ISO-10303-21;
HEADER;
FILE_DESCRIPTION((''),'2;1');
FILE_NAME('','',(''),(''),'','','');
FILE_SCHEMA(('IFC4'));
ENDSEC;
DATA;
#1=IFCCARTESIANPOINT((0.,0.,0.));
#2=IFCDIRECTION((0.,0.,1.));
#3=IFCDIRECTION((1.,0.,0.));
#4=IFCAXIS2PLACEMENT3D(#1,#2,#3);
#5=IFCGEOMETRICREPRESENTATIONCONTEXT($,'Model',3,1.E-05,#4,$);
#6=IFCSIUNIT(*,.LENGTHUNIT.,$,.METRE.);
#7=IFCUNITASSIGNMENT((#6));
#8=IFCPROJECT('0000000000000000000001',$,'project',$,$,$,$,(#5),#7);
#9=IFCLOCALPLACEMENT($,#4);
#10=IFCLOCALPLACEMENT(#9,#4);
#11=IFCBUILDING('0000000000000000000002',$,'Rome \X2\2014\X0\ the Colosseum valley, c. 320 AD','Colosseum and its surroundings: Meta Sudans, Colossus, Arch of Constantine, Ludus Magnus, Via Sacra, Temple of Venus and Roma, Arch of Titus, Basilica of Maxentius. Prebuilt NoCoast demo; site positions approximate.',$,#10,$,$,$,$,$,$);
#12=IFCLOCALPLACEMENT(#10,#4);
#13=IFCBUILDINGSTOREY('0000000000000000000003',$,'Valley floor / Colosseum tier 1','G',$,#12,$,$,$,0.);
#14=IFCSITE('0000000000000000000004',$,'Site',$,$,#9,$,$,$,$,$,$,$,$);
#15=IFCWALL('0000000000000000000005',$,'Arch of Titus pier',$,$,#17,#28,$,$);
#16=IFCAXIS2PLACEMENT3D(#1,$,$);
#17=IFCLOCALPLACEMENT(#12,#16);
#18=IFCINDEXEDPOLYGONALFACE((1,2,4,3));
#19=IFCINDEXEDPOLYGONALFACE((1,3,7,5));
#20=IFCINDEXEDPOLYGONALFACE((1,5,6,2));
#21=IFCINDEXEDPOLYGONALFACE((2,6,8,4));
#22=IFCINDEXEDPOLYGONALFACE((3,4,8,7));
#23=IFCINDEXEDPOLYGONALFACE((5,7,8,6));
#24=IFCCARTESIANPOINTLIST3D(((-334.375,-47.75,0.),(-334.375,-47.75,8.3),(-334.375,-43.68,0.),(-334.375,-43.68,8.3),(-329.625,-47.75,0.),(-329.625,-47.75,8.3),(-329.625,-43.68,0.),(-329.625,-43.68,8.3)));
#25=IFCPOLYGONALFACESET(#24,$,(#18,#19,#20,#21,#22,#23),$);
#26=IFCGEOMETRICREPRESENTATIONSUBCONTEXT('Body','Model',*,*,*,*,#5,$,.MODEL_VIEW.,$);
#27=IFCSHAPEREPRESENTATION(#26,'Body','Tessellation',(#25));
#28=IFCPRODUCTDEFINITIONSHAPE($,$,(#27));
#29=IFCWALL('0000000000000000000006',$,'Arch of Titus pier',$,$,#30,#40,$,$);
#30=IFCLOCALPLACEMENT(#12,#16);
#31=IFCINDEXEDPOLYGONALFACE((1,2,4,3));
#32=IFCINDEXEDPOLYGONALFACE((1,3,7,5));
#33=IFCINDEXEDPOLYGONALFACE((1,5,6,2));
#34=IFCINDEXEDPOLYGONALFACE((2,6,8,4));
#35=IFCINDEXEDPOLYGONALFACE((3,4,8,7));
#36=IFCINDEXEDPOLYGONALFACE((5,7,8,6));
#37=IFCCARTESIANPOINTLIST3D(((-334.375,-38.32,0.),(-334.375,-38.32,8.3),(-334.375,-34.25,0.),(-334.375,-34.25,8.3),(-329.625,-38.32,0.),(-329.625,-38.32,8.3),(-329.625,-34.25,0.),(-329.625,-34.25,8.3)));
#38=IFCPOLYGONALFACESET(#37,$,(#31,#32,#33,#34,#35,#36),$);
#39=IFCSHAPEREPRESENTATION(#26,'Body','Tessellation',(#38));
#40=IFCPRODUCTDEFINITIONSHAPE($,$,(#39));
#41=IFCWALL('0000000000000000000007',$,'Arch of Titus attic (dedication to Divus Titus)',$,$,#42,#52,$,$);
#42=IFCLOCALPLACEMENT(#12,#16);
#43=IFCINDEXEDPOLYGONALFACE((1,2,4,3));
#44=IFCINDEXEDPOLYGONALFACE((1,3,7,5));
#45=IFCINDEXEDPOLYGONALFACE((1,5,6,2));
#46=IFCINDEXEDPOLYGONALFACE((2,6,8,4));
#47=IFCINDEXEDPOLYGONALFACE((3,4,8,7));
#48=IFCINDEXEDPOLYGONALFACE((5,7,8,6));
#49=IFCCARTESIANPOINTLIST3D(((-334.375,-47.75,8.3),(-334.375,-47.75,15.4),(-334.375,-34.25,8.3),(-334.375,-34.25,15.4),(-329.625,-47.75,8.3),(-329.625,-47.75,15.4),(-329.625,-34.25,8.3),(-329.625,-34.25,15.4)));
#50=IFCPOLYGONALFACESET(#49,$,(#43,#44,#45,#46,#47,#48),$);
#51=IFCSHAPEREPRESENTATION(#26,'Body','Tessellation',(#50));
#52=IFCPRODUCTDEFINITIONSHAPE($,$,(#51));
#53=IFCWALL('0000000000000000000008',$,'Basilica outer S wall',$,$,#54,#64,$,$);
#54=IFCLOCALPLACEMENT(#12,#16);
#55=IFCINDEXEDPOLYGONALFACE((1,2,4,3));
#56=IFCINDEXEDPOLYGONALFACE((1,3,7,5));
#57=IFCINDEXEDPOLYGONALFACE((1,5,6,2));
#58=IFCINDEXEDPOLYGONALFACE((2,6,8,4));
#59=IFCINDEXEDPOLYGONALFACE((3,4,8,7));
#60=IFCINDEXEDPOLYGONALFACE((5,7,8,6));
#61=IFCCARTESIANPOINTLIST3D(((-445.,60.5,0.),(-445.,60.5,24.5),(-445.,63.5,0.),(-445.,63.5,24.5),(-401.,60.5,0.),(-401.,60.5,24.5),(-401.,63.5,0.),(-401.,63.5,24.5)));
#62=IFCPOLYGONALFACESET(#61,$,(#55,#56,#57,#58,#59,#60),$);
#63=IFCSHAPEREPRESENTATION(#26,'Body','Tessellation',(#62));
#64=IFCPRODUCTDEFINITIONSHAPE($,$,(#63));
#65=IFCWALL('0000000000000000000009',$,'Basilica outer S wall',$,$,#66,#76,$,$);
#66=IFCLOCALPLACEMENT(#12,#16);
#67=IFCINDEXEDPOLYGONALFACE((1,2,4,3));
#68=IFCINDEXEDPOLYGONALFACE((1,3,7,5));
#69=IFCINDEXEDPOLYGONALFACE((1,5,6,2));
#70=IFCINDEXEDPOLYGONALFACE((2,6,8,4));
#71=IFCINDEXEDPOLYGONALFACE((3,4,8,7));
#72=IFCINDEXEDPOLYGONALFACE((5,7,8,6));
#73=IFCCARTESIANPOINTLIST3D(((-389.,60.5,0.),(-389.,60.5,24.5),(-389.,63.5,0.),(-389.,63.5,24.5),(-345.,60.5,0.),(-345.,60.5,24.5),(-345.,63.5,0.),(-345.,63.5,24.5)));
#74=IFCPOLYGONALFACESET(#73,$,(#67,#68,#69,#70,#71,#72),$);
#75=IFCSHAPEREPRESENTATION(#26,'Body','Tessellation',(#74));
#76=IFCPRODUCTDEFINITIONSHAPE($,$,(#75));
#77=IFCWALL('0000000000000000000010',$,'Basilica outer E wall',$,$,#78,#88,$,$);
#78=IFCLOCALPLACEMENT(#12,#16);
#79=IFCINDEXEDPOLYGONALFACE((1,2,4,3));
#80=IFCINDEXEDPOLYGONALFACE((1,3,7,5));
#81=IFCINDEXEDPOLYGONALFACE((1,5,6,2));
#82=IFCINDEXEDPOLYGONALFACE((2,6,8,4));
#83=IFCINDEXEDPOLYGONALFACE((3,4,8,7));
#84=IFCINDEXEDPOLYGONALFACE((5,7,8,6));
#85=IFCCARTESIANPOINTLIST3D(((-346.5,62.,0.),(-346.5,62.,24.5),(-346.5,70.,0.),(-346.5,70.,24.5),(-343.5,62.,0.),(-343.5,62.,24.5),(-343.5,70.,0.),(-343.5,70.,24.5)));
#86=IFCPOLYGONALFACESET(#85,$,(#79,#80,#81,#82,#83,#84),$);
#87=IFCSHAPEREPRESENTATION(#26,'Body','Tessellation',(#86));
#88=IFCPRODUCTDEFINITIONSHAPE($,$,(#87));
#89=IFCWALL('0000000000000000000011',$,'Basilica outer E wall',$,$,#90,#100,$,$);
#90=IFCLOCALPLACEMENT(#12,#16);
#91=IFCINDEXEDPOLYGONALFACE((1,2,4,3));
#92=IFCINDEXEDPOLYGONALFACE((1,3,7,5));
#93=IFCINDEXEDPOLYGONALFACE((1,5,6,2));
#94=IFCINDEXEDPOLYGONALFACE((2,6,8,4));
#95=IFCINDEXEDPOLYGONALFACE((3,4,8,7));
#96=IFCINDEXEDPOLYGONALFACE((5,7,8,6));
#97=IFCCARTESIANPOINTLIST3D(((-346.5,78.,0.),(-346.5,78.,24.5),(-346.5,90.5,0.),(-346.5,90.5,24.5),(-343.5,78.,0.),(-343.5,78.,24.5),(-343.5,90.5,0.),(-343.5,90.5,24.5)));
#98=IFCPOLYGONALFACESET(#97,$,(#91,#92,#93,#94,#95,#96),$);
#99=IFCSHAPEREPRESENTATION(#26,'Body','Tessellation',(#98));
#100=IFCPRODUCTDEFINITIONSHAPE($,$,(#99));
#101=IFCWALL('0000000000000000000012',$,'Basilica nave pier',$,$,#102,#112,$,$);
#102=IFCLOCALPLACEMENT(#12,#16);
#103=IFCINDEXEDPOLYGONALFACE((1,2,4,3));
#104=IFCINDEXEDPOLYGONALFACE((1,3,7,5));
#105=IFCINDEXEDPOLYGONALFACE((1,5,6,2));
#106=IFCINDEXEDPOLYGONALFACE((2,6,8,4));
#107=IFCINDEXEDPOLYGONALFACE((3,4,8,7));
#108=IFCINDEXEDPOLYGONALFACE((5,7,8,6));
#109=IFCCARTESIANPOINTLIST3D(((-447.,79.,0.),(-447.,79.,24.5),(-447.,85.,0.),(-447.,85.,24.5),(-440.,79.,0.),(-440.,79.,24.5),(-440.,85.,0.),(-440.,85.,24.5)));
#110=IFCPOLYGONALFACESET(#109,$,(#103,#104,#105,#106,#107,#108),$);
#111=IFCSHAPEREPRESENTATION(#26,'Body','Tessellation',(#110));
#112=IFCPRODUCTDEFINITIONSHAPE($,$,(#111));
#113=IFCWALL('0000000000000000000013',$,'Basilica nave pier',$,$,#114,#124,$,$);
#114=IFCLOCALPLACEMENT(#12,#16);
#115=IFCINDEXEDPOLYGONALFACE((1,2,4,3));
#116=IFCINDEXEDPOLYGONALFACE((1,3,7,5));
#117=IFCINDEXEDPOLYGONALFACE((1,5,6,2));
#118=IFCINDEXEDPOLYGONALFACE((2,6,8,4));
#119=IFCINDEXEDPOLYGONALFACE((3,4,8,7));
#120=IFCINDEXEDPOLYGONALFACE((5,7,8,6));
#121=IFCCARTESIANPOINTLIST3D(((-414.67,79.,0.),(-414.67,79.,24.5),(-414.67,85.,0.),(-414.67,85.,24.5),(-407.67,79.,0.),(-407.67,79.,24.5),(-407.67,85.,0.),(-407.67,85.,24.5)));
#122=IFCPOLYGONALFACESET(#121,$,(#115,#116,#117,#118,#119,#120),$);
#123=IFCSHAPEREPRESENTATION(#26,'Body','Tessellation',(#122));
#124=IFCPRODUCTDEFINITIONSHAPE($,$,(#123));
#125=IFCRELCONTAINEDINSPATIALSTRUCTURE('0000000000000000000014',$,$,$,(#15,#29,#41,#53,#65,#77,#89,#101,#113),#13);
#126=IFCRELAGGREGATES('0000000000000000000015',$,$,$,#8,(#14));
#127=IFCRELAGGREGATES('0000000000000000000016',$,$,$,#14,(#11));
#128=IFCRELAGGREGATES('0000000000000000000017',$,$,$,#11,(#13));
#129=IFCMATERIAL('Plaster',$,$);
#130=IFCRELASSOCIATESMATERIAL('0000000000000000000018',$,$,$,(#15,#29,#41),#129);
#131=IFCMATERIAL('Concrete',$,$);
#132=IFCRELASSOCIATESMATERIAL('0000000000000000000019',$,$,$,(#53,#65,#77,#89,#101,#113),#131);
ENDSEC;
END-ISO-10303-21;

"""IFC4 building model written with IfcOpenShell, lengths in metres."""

from ifc_helpers import new_model, si_unit, frame, origin_with_axes, place, context, subcontext, project, spatial, indexed_curve, outline, extrude, material, element, save


model = new_model("IFC4")

# Units and contexts
model_context = context("Model", 3, precision=1e-05, world=origin_with_axes())
body_context = subcontext(model_context, "Body", "Model", "MODEL_VIEW")
ifc_project = project(units=[si_unit("LENGTHUNIT", "METRE")], contexts=[model_context])

# Site, building, storey
site_placement = place(None, origin_with_axes())
site = spatial("IfcSite", under=ifc_project, at=site_placement, Name="Site")
building_placement = place(site_placement, origin_with_axes())
building = spatial("IfcBuilding", under=site, at=building_placement, Name="Rome — the Colosseum valley, c. 320 AD", Description="Colosseum and its surroundings: Meta Sudans, Colossus, Arch of Constantine, Ludus Magnus, Via Sacra, Temple of Venus and Roma, Arch of Titus, Basilica of Maxentius. Prebuilt NoCoast demo; site positions approximate.")
storey_placement = place(building_placement, origin_with_axes())
storey = spatial("IfcBuildingStorey", under=building, at=storey_placement, Name="Valley floor / Colosseum tier 1", Description="G", Elevation=0.0)

# Walls
ifc_material_1 = material(Name="Plaster")
for number, where, z_axis, x_axis, name in (
    (1, (-332.0, -47.75, 0.0), (0.0, 0.0, 1.0), (0.0, 1.0, 0.0), "Arch of Titus pier"),
    (2, (-332.0, -38.32, 0.0), (0.0, 0.0, 1.0), (0.0, 1.0, 0.0), "Arch of Titus pier"),
):
    element("IfcWall", number, at=place(storey_placement, frame(where, z_axis=z_axis, x_axis=x_axis)), inside=storey, material=ifc_material_1, Name=name, context=body_context, shape_type="SweptSolid", body=[
        extrude(outline(indexed_curve([(0.0, 0.0), (0.0, 4.75), (4.07, 4.75), (4.07, 0.0), (0.0, 0.0)], self_intersect=False)), frame((0.0, -2.375, 0.0), z_axis=(0.0, 0.0, 1.0), x_axis=(1.0, 0.0, 0.0)), (0.0, 0.0, 1.0), 8.3),
    ])
wall_1_placement = place(storey_placement, frame((-332.0, -47.75, 8.3), z_axis=(0.0, 0.0, 1.0), x_axis=(0.0, 1.0, 0.0)))
element("IfcWall", 3, at=wall_1_placement, inside=storey, material=ifc_material_1, Name="Arch of Titus attic (dedication to Divus Titus)", context=body_context, shape_type="SweptSolid", body=[
    extrude(outline(indexed_curve([(0.0, 0.0), (0.0, 4.75), (13.5, 4.75), (13.5, 0.0), (0.0, 0.0)], self_intersect=False)), frame((0.0, -2.375, 0.0), z_axis=(0.0, 0.0, 1.0), x_axis=(1.0, 0.0, 0.0)), (0.0, 0.0, 1.0), 7.1),
])
ifc_material_2 = material(Name="Concrete")
for number, where, z_axis, x_axis, name in (
    (4, (-445.0, 62.0, 0.0), (0.0, 0.0, 1.0), (1.0, 0.0, 0.0), "Basilica outer S wall"),
    (5, (-389.0, 62.0, 0.0), (0.0, 0.0, 1.0), (1.0, 0.0, 0.0), "Basilica outer S wall"),
):
    element("IfcWall", number, at=place(storey_placement, frame(where, z_axis=z_axis, x_axis=x_axis)), inside=storey, material=ifc_material_2, Name=name, context=body_context, shape_type="SweptSolid", body=[
        extrude(outline(indexed_curve([(0.0, 0.0), (0.0, 3.0), (44.0, 3.0), (44.0, 0.0), (0.0, 0.0)], self_intersect=False)), frame((0.0, -1.5, 0.0), z_axis=(0.0, 0.0, 1.0), x_axis=(1.0, 0.0, 0.0)), (0.0, 0.0, 1.0), 24.5),
    ])
wall_2_placement = place(storey_placement, frame((-345.0, 62.0, 0.0), z_axis=(0.0, 0.0, 1.0), x_axis=(0.0, 1.0, 0.0)))
element("IfcWall", 6, at=wall_2_placement, inside=storey, material=ifc_material_2, Name="Basilica outer E wall", context=body_context, shape_type="SweptSolid", body=[
    extrude(outline(indexed_curve([(0.0, 0.0), (0.0, 3.0), (8.0, 3.0), (8.0, 0.0), (0.0, 0.0)], self_intersect=False)), frame((0.0, -1.5, 0.0), z_axis=(0.0, 0.0, 1.0), x_axis=(1.0, 0.0, 0.0)), (0.0, 0.0, 1.0), 24.5),
])
wall_3_placement = place(storey_placement, frame((-345.0, 78.0, 0.0), z_axis=(0.0, 0.0, 1.0), x_axis=(0.0, 1.0, 0.0)))
element("IfcWall", 7, at=wall_3_placement, inside=storey, material=ifc_material_2, Name="Basilica outer E wall", context=body_context, shape_type="SweptSolid", body=[
    extrude(outline(indexed_curve([(0.0, 0.0), (0.0, 3.0), (12.5, 3.0), (12.5, 0.0), (0.0, 0.0)], self_intersect=False)), frame((0.0, -1.5, 0.0), z_axis=(0.0, 0.0, 1.0), x_axis=(1.0, 0.0, 0.0)), (0.0, 0.0, 1.0), 24.5),
])
for number, where, z_axis, x_axis, name in (
    (8, (-447.0, 82.0, 0.0), (0.0, 0.0, 1.0), (1.0, 0.0, 0.0), "Basilica nave pier"),
    (9, (-414.67, 82.0, 0.0), (0.0, 0.0, 1.0), (1.0, 0.0, 0.0), "Basilica nave pier"),
):
    element("IfcWall", number, at=place(storey_placement, frame(where, z_axis=z_axis, x_axis=x_axis)), inside=storey, material=ifc_material_2, Name=name, context=body_context, shape_type="SweptSolid", body=[
        extrude(outline(indexed_curve([(0.0, 0.0), (0.0, 6.0), (7.0, 6.0), (7.0, 0.0), (0.0, 0.0)], self_intersect=False)), frame((0.0, -3.0, 0.0), z_axis=(0.0, 0.0, 1.0), x_axis=(1.0, 0.0, 0.0)), (0.0, 0.0, 1.0), 24.5),
    ])

save(model, "model.ifc")
